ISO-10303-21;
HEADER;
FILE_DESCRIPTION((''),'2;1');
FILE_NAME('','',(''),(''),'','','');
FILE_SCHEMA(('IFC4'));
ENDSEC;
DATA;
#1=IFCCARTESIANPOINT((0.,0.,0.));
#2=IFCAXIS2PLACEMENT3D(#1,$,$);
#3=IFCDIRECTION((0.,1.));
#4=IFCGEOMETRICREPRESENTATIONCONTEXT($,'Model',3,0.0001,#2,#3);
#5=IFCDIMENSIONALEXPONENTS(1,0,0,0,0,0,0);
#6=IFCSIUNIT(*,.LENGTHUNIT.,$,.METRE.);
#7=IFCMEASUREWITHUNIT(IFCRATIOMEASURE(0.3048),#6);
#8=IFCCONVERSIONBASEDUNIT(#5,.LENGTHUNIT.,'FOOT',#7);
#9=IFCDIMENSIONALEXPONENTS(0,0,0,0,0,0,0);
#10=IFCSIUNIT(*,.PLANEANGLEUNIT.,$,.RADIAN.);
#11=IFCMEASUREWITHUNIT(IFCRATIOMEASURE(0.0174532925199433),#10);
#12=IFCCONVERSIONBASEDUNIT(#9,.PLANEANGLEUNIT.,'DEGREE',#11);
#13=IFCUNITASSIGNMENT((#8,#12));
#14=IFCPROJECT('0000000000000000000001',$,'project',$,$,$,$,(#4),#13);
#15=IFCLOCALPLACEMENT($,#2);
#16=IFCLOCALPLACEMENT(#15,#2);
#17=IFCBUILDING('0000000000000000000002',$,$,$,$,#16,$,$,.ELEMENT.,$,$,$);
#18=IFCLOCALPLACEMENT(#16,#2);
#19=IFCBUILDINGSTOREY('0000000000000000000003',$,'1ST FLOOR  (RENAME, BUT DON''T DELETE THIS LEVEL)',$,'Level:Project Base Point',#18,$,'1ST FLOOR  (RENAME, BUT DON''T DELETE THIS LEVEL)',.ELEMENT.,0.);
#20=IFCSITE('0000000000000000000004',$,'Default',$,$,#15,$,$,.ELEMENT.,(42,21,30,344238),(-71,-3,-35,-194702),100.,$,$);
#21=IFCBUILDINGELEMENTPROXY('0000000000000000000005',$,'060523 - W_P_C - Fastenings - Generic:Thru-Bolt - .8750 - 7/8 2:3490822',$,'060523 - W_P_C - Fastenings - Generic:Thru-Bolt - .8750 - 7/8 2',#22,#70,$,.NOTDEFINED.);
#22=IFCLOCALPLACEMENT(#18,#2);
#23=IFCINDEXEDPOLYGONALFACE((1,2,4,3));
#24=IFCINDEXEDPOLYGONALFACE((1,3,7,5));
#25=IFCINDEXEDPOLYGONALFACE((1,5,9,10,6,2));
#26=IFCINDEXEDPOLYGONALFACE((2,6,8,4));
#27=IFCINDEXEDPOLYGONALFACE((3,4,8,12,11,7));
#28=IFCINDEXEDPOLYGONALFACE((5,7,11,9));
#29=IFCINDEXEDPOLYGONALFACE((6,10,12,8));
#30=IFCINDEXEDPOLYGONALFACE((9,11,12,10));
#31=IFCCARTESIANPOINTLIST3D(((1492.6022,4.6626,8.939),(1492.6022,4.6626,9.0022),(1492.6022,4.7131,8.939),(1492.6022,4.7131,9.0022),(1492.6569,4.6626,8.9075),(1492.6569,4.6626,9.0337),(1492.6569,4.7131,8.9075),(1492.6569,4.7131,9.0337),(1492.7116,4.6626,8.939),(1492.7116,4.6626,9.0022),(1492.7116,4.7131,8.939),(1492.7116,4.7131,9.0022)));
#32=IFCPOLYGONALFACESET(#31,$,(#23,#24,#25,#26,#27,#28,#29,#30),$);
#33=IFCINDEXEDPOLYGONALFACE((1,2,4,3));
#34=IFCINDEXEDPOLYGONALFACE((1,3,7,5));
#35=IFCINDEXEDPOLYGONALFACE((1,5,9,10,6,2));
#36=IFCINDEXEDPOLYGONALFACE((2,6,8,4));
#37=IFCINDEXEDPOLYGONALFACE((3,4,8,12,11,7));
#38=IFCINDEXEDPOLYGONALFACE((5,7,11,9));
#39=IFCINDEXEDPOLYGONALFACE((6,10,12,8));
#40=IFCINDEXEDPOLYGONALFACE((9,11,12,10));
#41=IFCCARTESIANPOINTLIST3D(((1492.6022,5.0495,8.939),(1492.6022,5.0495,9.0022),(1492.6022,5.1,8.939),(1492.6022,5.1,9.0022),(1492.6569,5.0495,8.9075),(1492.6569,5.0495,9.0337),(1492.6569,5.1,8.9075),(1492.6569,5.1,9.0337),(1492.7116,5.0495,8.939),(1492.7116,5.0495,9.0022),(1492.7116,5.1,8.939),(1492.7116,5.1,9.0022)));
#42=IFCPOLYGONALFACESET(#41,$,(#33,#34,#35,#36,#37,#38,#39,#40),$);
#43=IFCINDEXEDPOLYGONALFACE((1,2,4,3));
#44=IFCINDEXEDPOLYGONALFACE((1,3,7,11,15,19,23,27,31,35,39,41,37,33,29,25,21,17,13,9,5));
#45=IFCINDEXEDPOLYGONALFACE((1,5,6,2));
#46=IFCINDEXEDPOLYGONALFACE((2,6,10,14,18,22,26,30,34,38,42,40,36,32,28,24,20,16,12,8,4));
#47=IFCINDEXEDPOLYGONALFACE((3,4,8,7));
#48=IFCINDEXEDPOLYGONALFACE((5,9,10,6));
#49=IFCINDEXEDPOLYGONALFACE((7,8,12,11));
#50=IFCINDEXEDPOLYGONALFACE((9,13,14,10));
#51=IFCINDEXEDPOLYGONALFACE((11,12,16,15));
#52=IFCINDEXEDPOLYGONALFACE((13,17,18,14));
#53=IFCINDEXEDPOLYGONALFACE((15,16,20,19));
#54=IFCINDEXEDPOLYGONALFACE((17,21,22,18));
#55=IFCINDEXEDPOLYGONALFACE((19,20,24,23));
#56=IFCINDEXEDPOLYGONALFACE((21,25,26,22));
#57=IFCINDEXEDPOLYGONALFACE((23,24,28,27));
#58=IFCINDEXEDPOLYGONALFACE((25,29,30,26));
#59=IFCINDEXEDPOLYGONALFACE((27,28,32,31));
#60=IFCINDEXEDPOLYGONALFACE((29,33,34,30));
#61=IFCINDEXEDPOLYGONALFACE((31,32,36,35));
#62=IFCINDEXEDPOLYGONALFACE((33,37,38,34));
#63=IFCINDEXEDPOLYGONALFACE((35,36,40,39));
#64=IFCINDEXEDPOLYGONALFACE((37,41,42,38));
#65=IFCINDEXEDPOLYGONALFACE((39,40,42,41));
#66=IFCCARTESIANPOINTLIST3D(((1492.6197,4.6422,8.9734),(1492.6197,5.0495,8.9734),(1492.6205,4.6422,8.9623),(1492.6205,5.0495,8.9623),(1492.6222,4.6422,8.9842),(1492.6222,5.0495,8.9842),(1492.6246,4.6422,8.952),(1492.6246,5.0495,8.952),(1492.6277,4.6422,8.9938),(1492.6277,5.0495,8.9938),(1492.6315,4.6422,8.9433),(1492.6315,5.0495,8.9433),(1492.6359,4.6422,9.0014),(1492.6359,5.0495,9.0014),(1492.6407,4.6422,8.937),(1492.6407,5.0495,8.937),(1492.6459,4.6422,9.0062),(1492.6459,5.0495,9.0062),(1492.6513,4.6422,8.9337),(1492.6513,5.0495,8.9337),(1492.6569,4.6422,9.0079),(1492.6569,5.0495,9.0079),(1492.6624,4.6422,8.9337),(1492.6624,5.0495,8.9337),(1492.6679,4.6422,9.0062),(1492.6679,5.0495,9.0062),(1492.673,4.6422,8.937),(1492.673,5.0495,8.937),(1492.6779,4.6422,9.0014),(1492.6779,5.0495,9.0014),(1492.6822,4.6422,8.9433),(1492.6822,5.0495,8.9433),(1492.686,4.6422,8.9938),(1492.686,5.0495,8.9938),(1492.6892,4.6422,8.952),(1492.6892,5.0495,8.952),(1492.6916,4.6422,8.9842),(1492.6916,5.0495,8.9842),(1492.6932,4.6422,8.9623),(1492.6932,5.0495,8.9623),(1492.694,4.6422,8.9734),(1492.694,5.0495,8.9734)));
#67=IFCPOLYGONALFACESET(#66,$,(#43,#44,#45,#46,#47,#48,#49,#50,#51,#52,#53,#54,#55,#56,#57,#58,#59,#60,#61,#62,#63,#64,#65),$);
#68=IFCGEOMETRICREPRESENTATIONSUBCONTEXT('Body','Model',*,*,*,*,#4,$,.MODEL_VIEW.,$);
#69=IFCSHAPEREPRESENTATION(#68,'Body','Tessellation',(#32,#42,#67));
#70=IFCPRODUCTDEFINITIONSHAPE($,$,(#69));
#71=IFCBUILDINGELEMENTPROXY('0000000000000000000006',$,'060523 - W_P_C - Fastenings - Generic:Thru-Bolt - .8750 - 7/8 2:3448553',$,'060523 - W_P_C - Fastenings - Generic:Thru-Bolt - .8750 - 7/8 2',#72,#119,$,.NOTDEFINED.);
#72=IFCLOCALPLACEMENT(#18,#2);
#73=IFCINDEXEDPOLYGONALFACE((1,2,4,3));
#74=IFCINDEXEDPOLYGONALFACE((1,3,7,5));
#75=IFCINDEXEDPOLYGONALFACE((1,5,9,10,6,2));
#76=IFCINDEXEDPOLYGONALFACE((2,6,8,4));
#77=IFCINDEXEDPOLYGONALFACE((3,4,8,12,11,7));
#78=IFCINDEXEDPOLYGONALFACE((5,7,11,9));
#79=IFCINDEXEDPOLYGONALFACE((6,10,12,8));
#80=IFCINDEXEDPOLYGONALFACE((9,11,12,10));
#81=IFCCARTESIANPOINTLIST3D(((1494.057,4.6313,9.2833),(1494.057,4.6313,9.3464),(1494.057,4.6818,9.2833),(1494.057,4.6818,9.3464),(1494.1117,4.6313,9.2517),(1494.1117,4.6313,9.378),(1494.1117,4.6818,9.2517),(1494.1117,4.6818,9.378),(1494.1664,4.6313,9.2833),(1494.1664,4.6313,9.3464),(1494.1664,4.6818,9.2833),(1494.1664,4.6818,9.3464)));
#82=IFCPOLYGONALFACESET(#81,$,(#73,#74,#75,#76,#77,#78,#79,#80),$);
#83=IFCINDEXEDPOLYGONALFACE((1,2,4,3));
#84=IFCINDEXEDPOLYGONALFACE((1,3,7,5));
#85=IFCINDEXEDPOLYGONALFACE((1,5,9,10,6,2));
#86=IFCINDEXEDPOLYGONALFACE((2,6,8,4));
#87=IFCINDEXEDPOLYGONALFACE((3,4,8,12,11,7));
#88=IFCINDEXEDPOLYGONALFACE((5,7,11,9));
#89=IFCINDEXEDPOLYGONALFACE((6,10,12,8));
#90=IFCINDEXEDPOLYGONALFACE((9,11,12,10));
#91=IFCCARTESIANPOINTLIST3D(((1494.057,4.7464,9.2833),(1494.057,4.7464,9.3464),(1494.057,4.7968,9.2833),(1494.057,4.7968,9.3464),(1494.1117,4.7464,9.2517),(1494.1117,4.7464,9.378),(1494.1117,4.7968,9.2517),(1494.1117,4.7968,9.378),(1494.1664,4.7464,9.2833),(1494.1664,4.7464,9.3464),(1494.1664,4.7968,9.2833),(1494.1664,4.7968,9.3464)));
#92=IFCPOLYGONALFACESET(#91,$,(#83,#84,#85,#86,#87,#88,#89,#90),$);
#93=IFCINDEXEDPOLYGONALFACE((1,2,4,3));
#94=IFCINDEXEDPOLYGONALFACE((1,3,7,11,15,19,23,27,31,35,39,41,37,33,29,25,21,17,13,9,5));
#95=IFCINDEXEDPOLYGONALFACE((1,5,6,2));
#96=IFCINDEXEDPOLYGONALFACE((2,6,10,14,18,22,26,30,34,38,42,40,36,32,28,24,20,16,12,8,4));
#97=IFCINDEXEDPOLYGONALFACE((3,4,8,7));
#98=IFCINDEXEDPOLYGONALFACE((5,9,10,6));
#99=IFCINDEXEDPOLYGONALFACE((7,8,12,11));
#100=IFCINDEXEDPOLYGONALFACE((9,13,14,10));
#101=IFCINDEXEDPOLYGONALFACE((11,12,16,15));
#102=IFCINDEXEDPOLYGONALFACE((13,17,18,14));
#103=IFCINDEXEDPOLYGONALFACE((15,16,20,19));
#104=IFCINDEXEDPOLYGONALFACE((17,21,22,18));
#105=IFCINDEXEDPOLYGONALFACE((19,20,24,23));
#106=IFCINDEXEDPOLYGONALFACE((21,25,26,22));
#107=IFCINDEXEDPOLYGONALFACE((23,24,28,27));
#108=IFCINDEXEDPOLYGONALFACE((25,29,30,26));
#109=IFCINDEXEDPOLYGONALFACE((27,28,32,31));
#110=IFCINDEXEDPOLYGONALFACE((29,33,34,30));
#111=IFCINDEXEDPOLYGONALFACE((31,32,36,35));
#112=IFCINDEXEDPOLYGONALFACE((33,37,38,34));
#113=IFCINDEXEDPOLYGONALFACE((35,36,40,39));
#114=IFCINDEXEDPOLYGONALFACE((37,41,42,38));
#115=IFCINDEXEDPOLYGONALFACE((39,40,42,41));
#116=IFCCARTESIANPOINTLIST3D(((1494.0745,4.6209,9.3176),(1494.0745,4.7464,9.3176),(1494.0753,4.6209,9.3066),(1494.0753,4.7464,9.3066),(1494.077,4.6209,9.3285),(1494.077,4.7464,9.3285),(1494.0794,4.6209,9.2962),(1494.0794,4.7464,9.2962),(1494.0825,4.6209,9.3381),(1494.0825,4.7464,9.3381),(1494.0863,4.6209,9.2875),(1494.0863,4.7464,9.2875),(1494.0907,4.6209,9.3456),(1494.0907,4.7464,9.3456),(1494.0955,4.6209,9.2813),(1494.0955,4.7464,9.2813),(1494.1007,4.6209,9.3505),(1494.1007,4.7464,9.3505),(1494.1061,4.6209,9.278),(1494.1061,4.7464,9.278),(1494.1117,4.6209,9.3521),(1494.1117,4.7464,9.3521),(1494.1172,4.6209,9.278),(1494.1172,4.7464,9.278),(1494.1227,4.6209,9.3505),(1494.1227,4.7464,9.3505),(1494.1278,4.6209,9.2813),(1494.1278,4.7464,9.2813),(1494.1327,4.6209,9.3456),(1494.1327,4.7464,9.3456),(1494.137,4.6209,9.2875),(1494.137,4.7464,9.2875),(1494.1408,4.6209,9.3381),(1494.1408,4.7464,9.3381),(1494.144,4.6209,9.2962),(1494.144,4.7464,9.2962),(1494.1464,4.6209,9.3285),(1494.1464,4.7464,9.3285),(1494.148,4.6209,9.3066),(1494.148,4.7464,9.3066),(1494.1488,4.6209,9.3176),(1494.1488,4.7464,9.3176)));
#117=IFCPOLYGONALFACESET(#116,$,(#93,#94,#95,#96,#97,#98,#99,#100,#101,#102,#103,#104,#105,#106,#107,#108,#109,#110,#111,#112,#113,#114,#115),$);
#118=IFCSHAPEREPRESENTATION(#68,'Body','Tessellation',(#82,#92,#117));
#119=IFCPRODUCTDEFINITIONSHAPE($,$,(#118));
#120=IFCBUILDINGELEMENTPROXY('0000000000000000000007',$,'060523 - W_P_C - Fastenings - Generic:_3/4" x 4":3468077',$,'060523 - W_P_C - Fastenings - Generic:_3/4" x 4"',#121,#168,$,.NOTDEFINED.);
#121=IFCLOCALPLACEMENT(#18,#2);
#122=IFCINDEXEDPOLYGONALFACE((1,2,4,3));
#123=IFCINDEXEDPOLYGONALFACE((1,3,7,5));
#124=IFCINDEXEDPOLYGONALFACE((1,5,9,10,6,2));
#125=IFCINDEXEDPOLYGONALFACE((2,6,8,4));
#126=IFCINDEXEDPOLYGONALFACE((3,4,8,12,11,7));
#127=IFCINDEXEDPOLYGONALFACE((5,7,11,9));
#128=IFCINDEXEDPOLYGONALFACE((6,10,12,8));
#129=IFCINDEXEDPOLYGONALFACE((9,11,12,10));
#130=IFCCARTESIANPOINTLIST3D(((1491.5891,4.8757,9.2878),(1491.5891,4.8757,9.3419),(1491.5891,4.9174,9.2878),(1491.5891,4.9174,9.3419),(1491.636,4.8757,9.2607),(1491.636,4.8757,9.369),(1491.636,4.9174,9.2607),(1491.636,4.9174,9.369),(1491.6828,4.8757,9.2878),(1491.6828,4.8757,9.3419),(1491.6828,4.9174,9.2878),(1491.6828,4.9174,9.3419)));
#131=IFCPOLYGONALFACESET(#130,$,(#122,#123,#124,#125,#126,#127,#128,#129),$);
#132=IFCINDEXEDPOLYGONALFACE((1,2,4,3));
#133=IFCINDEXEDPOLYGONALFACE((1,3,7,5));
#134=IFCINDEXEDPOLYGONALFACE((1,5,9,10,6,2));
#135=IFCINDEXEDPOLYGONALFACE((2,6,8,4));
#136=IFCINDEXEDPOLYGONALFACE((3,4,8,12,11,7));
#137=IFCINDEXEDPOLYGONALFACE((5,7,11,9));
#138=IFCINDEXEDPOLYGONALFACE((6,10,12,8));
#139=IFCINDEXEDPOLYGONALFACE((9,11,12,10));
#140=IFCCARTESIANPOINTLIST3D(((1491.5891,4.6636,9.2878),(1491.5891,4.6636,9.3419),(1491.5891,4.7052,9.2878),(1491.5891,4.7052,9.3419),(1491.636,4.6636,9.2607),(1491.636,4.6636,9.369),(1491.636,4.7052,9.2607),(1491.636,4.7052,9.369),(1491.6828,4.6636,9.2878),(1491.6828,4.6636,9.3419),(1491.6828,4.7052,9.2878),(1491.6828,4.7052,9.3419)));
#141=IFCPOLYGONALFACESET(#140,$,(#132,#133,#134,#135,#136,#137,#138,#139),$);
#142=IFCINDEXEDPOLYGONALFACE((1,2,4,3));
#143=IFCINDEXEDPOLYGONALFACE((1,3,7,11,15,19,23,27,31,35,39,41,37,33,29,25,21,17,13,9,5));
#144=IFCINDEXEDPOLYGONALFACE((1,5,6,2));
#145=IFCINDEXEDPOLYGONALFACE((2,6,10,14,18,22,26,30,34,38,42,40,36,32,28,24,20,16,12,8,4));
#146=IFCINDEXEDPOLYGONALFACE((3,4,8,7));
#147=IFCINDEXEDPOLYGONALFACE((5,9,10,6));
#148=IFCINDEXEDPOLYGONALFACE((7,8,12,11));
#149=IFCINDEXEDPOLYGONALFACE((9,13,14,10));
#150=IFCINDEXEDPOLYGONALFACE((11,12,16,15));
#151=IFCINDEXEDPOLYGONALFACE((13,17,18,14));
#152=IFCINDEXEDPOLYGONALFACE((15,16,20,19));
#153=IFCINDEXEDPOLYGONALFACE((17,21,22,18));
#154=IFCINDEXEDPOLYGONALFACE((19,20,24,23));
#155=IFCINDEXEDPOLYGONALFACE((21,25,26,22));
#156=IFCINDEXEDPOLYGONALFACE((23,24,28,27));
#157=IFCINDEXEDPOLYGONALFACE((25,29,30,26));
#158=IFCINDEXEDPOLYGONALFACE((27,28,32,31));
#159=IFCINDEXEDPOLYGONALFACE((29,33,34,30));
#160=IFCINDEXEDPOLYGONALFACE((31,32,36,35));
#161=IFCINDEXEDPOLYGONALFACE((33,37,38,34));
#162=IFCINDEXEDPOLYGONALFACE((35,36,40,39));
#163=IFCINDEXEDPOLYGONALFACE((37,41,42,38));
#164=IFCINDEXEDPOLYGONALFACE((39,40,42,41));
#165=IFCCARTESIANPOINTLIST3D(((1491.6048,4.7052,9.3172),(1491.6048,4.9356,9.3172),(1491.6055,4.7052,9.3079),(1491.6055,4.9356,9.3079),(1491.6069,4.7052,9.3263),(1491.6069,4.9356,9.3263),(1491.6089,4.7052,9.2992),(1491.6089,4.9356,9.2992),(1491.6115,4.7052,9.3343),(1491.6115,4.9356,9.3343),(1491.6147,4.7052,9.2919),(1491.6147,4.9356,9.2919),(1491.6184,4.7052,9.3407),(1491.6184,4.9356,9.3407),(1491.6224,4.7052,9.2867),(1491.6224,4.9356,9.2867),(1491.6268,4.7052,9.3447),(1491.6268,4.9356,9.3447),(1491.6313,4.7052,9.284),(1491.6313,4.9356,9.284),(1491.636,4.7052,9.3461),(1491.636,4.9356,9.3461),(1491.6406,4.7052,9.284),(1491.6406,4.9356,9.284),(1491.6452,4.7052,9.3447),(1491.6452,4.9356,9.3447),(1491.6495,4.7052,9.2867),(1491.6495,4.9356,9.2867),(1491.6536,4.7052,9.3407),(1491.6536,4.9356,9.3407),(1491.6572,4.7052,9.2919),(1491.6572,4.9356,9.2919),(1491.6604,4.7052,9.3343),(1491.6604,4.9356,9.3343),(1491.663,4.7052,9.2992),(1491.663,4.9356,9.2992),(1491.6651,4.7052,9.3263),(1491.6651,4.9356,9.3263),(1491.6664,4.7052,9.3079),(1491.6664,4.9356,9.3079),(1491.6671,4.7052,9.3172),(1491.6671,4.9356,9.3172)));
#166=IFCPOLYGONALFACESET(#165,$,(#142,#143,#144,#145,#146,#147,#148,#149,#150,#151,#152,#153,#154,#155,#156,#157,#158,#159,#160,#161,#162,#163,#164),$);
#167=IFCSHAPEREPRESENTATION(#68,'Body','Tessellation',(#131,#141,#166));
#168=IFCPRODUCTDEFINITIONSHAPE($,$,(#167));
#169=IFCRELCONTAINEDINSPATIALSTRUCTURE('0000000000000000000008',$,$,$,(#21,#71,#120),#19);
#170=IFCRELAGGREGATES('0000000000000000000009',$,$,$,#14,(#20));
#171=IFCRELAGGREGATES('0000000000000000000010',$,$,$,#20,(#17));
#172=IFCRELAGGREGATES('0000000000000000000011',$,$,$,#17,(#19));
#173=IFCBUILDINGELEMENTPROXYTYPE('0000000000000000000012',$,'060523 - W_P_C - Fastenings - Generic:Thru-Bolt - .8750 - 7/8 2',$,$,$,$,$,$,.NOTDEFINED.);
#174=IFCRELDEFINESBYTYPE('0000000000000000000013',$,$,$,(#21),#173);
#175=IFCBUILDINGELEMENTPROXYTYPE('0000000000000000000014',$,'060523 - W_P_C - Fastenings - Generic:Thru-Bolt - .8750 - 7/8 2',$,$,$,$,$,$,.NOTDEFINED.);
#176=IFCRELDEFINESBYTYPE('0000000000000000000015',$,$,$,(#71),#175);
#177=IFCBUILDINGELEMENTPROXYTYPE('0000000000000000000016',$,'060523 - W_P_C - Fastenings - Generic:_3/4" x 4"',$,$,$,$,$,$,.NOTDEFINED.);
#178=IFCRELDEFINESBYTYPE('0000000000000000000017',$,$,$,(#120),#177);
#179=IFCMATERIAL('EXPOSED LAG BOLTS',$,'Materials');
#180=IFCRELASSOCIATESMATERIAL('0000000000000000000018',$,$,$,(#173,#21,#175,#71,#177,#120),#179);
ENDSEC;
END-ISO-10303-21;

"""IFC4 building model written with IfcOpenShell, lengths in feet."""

from ifc_helpers import new_model, entity, si_unit, converted_unit, direction, frame, frame_2d, origin, place, context, subcontext, project, spatial, polyline, circle, outline, extrude, source, transform, mapped, material, type_object, type_shapes, element, save


model = new_model("IFC4")

# Units and contexts
model_context = context("Model", 3, precision=0.0001, world=origin(), true_north=direction((0.0, 1.0)))
body_context = subcontext(model_context, "Body", "Model", "MODEL_VIEW")
ifc_project = project(units=[converted_unit("LENGTHUNIT", "FOOT", entity("IfcRatioMeasure", 0.3048), si_unit("LENGTHUNIT", "METRE"), dimensions=[1, 0, 0, 0, 0, 0, 0]), converted_unit("PLANEANGLEUNIT", "DEGREE", entity("IfcRatioMeasure", 0.0174532925199433), si_unit("PLANEANGLEUNIT", "RADIAN"), dimensions=[0, 0, 0, 0, 0, 0, 0])], contexts=[model_context])

# Site, building, storey
site_placement = place(None, origin())
site = spatial("IfcSite", under=ifc_project, at=site_placement, Name="Default", CompositionType="ELEMENT", RefLatitude=(42, 21, 30, 344238), RefLongitude=(-71, -3, -35, -194702), RefElevation=100.0)
building_placement = place(site_placement, origin())
building = spatial("IfcBuilding", under=site, at=building_placement, CompositionType="ELEMENT")
storey_placement = place(building_placement, origin())
storey = spatial("IfcBuildingStorey", under=building, at=storey_placement, Name="1ST FLOOR  (RENAME, BUT DON'T DELETE THIS LEVEL)", ObjectType="Level:Project Base Point", LongName="1ST FLOOR  (RENAME, BUT DON'T DELETE THIS LEVEL)", CompositionType="ELEMENT", Elevation=0.0)

# Building element proxies
ifc_material_1 = material(Name="EXPOSED LAG BOLTS", Category="Materials")
building_element_proxy_type_1 = type_object("IfcBuildingElementProxyType", Name="060523 - W_P_C - Fastenings - Generic:Thru-Bolt - .8750 - 7/8 2", PredefinedType="NOTDEFINED", material=ifc_material_1)
shared_shape_1 = source(origin(), body_context, "Body", "SweptSolid", [
    extrude(outline(polyline([(-0.0316, -0.0547), (0.0316, -0.0547), (0.0631, 0.0), (0.0316, 0.0547), (-0.0316, 0.0547), (-0.0631, 0.0), (-0.0316, -0.0547)])), frame((0.0, 0.0, -0.3869), z_axis=(0.0, 0.0, 1.0), x_axis=(0.866025, -0.5, 0.0)), (0.0, 0.0, 1.0), 0.0505),
    extrude(outline(polyline([(-0.0316, -0.0547), (0.0316, -0.0547), (0.0631, 0.0), (0.0316, 0.0547), (-0.0316, 0.0547), (-0.0631, 0.0), (-0.0316, -0.0547)])), frame((0.0, 0.0, 0.0), z_axis=(0.0, 0.0, 1.0), x_axis=(0.0, -1.0, 0.0)), (0.0, 0.0, 1.0), 0.0505),
    extrude(circle(Radius=0.0373, at=frame_2d((0.0, 0.0), x_axis=(1.0, 0.0))), frame((0.0, 0.0, -0.4073), z_axis=(0.0, 0.0, 1.0), x_axis=(0.0, 1.0, 0.0)), (0.0, 0.0, 1.0), 0.4073),
])
type_shapes(building_element_proxy_type_1, [shared_shape_1])
for number, where, z_axis, x_axis, name in (
    (1, (1492.6569, 5.0495, 8.9706), (0.0, 1.0, 0.0), (-1.0, 0.0, 0.0), "060523 - W_P_C - Fastenings - Generic:Thru-Bolt - .8750 - 7/8 2:3490822"),
):
    element("IfcBuildingElementProxy", number, at=place(storey_placement, frame(where, z_axis=z_axis, x_axis=x_axis)), inside=storey, type_object=building_element_proxy_type_1, material=ifc_material_1, Name=name, ObjectType="060523 - W_P_C - Fastenings - Generic:Thru-Bolt - .8750 - 7/8 2", PredefinedType="NOTDEFINED", context=body_context, shape_type="MappedRepresentation", body=[
        mapped(shared_shape_1, transform((0.0, 0.0, 0.0), scale=1.0)),
    ])
building_element_proxy_type_2 = type_object("IfcBuildingElementProxyType", Name="060523 - W_P_C - Fastenings - Generic:Thru-Bolt - .8750 - 7/8 2", PredefinedType="NOTDEFINED", material=ifc_material_1)
shared_shape_2 = source(origin(), body_context, "Body", "SweptSolid", [
    extrude(outline(polyline([(-0.0316, -0.0547), (0.0316, -0.0547), (0.0631, 0.0), (0.0316, 0.0547), (-0.0316, 0.0547), (-0.0631, 0.0), (-0.0316, -0.0547)])), frame((0.0, 0.0, -0.115), z_axis=(0.0, 0.0, 1.0), x_axis=(0.866025, -0.5, 0.0)), (0.0, 0.0, 1.0), 0.0505),
    extrude(outline(polyline([(-0.0316, -0.0547), (0.0316, -0.0547), (0.0631, 0.0), (0.0316, 0.0547), (-0.0316, 0.0547), (-0.0631, 0.0), (-0.0316, -0.0547)])), frame((0.0, 0.0, 0.0), z_axis=(0.0, 0.0, 1.0), x_axis=(0.0, -1.0, 0.0)), (0.0, 0.0, 1.0), 0.0505),
    extrude(circle(Radius=0.0373, at=frame_2d((0.0, 0.0), x_axis=(1.0, 0.0))), frame((0.0, 0.0, -0.1255), z_axis=(0.0, 0.0, 1.0), x_axis=(0.0, 1.0, 0.0)), (0.0, 0.0, 1.0), 0.1255),
])
type_shapes(building_element_proxy_type_2, [shared_shape_2])
proxy_1_placement = place(storey_placement, frame((1494.1117, 4.7464, 9.3149), z_axis=(0.0, 1.0, 0.0), x_axis=(-1.0, 0.0, 0.0)))
element("IfcBuildingElementProxy", 2, at=proxy_1_placement, inside=storey, type_object=building_element_proxy_type_2, material=ifc_material_1, Name="060523 - W_P_C - Fastenings - Generic:Thru-Bolt - .8750 - 7/8 2:3448553", ObjectType="060523 - W_P_C - Fastenings - Generic:Thru-Bolt - .8750 - 7/8 2", PredefinedType="NOTDEFINED", context=body_context, shape_type="MappedRepresentation", body=[
    mapped(shared_shape_2, transform((0.0, 0.0, 0.0), scale=1.0)),
])
building_element_proxy_type_3 = type_object("IfcBuildingElementProxyType", Name="060523 - W_P_C - Fastenings - Generic:_3/4\" x 4\"", PredefinedType="NOTDEFINED", material=ifc_material_1)
shared_shape_3 = source(origin(), body_context, "Body", "SweptSolid", [
    extrude(outline(polyline([(-0.0271, -0.0469), (0.0271, -0.0469), (0.0541, 0.0), (0.0271, 0.0469), (-0.0271, 0.0469), (-0.0541, 0.0), (-0.0271, -0.0469)])), frame((0.0, 0.0, -0.2121), z_axis=(0.0, 0.0, 1.0), x_axis=(0.866025, -0.5, 0.0)), (0.0, 0.0, 1.0), 0.0417),
    extrude(outline(polyline([(-0.0271, -0.0469), (0.0271, -0.0469), (0.0541, 0.0), (0.0271, 0.0469), (-0.0271, 0.0469), (-0.0541, 0.0), (-0.0271, -0.0469)])), frame((0.0, 0.0, 0.0), z_axis=(0.0, 0.0, 1.0), x_axis=(0.0, -1.0, 0.0)), (0.0, 0.0, 1.0), 0.0417),
    extrude(circle(Radius=0.0312, at=frame_2d((0.0, 0.0), x_axis=(1.0, 0.0))), frame((0.0, 0.0, -0.2304), z_axis=(0.0, 0.0, 1.0), x_axis=(0.0, 1.0, 0.0)), (0.0, 0.0, 1.0), 0.2304),
])
type_shapes(building_element_proxy_type_3, [shared_shape_3])
proxy_2_placement = place(storey_placement, frame((1491.636, 4.7052, 9.3149), z_axis=(0.0, -1.0, 0.0), x_axis=(1.0, 0.0, 0.0)))
element("IfcBuildingElementProxy", 3, at=proxy_2_placement, inside=storey, type_object=building_element_proxy_type_3, material=ifc_material_1, Name="060523 - W_P_C - Fastenings - Generic:_3/4\" x 4\":3468077", ObjectType="060523 - W_P_C - Fastenings - Generic:_3/4\" x 4\"", PredefinedType="NOTDEFINED", context=body_context, shape_type="MappedRepresentation", body=[
    mapped(shared_shape_3, transform((0.0, 0.0, 0.0), scale=1.0)),
])

save(model, "model.ifc")
